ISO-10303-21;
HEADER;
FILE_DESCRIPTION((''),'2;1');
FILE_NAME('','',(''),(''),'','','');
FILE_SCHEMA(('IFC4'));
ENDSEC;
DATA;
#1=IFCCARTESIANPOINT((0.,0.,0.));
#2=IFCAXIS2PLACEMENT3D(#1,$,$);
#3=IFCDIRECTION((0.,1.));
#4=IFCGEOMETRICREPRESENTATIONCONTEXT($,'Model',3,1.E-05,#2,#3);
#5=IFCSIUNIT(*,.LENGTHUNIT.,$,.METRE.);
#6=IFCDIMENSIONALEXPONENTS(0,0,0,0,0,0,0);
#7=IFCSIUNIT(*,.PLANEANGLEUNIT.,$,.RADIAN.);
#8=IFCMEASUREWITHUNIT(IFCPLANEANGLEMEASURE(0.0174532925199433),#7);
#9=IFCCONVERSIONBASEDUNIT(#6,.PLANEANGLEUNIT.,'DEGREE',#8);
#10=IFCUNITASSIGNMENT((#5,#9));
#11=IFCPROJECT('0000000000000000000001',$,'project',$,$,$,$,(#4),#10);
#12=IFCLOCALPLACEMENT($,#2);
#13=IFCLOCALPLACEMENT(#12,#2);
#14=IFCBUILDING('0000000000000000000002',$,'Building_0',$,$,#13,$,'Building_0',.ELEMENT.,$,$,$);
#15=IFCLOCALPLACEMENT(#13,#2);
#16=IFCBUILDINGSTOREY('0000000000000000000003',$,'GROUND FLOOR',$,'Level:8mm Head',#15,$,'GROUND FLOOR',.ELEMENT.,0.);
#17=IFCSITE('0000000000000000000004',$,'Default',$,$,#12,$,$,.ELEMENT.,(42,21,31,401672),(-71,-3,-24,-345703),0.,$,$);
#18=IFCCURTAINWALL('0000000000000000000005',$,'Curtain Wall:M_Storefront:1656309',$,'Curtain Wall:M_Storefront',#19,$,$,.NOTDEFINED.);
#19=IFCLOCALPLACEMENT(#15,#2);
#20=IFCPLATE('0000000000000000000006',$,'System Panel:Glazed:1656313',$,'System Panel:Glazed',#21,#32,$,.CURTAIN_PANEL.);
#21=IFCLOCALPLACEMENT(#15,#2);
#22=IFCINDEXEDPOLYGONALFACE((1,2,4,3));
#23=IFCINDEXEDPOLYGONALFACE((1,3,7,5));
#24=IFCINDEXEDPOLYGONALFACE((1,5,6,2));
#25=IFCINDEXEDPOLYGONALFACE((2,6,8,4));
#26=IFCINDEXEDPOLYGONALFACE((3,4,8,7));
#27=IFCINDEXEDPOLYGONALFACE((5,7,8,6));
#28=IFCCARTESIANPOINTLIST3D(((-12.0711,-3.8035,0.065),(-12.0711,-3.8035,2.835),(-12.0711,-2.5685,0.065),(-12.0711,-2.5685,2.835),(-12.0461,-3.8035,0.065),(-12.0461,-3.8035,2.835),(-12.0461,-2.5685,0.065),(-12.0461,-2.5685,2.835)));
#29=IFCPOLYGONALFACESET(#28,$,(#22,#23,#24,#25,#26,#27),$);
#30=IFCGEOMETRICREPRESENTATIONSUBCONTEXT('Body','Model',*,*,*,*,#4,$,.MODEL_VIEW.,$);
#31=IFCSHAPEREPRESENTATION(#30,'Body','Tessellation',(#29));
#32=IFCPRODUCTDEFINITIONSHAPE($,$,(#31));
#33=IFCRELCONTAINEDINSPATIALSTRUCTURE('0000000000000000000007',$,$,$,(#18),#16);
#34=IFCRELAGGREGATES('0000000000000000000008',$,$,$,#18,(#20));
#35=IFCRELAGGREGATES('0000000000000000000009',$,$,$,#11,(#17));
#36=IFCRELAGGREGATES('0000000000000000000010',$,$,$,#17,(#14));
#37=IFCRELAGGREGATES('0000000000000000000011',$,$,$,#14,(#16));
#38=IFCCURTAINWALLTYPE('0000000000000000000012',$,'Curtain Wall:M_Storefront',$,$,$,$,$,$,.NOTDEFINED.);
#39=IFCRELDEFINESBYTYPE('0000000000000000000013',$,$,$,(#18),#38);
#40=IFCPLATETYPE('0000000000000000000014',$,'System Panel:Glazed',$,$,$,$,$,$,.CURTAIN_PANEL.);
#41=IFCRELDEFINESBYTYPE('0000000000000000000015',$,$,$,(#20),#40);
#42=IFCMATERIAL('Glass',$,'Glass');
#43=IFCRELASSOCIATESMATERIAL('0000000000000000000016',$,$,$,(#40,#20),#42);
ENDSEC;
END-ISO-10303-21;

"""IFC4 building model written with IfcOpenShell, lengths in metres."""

from ifc_helpers import new_model, entity, si_unit, converted_unit, direction, frame, origin, place, context, subcontext, project, spatial, indexed_curve, outline, extrude, source, transform, mapped, material, type_object, type_shapes, element, aggregate, save


model = new_model("IFC4")

# Units and contexts
model_context = context("Model", 3, precision=1e-05, world=origin(), true_north=direction((0.0, 1.0)))
body_context = subcontext(model_context, "Body", "Model", "MODEL_VIEW")
ifc_project = project(units=[si_unit("LENGTHUNIT", "METRE"), converted_unit("PLANEANGLEUNIT", "DEGREE", entity("IfcPlaneAngleMeasure", 0.0174532925199433), si_unit("PLANEANGLEUNIT", "RADIAN"), dimensions=[0, 0, 0, 0, 0, 0, 0])], contexts=[model_context])

# Site, building, storey
site_placement = place(None, origin())
site = spatial("IfcSite", under=ifc_project, at=site_placement, Name="Default", CompositionType="ELEMENT", RefLatitude=(42, 21, 31, 401672), RefLongitude=(-71, -3, -24, -345703), RefElevation=0.0)
building_placement = place(site_placement, origin())
building = spatial("IfcBuilding", under=site, at=building_placement, Name="Building_0", LongName="Building_0", CompositionType="ELEMENT")
storey_placement = place(building_placement, origin())
storey = spatial("IfcBuildingStorey", under=building, at=storey_placement, Name="GROUND FLOOR", ObjectType="Level:8mm Head", LongName="GROUND FLOOR", CompositionType="ELEMENT", Elevation=0.0)

# Curtain wall
curtain_wall_type = type_object("IfcCurtainWallType", Name="Curtain Wall:M_Storefront", PredefinedType="NOTDEFINED")
curtain_wall_1_placement = place(storey_placement, origin())
curtain_wall_1 = element("IfcCurtainWall", 1, at=curtain_wall_1_placement, inside=storey, type_object=curtain_wall_type, Name="Curtain Wall:M_Storefront:1656309", ObjectType="Curtain Wall:M_Storefront", PredefinedType="NOTDEFINED")

# Plate
ifc_material_1 = material(Name="Glass", Category="Glass")
plate_type_1 = type_object("IfcPlateType", Name="System Panel:Glazed", PredefinedType="CURTAIN_PANEL", material=ifc_material_1)
shared_shape_1 = source(origin(), body_context, "Body", "SweptSolid", [
    extrude(outline(indexed_curve([(-0.0125, -0.6175), (0.0125, -0.6175), (0.0125, 0.6175), (-0.0125, 0.6175), (-0.0125, -0.6175)], self_intersect=False)), frame((0.0, 0.037, 0.0), z_axis=(0.0, 0.0, 1.0), x_axis=(0.0, 1.0, 0.0)), (0.0, 0.0, 1.0), 2.77),
])
type_shapes(plate_type_1, [shared_shape_1])
plate_1_placement = place(curtain_wall_1_placement, frame((-12.0956, -3.186, 0.065), z_axis=(0.0, 0.0, 1.0), x_axis=(0.0, -1.0, 0.0)))
plate_1 = element("IfcPlate", 2, at=plate_1_placement, type_object=plate_type_1, material=ifc_material_1, Name="System Panel:Glazed:1656313", ObjectType="System Panel:Glazed", PredefinedType="CURTAIN_PANEL", context=body_context, shape_type="MappedRepresentation", body=[
    mapped(shared_shape_1, transform((0.0, 0.0, 0.0), scale=1.0)),
])
aggregate(curtain_wall_1, [plate_1])

save(model, "model.ifc")
